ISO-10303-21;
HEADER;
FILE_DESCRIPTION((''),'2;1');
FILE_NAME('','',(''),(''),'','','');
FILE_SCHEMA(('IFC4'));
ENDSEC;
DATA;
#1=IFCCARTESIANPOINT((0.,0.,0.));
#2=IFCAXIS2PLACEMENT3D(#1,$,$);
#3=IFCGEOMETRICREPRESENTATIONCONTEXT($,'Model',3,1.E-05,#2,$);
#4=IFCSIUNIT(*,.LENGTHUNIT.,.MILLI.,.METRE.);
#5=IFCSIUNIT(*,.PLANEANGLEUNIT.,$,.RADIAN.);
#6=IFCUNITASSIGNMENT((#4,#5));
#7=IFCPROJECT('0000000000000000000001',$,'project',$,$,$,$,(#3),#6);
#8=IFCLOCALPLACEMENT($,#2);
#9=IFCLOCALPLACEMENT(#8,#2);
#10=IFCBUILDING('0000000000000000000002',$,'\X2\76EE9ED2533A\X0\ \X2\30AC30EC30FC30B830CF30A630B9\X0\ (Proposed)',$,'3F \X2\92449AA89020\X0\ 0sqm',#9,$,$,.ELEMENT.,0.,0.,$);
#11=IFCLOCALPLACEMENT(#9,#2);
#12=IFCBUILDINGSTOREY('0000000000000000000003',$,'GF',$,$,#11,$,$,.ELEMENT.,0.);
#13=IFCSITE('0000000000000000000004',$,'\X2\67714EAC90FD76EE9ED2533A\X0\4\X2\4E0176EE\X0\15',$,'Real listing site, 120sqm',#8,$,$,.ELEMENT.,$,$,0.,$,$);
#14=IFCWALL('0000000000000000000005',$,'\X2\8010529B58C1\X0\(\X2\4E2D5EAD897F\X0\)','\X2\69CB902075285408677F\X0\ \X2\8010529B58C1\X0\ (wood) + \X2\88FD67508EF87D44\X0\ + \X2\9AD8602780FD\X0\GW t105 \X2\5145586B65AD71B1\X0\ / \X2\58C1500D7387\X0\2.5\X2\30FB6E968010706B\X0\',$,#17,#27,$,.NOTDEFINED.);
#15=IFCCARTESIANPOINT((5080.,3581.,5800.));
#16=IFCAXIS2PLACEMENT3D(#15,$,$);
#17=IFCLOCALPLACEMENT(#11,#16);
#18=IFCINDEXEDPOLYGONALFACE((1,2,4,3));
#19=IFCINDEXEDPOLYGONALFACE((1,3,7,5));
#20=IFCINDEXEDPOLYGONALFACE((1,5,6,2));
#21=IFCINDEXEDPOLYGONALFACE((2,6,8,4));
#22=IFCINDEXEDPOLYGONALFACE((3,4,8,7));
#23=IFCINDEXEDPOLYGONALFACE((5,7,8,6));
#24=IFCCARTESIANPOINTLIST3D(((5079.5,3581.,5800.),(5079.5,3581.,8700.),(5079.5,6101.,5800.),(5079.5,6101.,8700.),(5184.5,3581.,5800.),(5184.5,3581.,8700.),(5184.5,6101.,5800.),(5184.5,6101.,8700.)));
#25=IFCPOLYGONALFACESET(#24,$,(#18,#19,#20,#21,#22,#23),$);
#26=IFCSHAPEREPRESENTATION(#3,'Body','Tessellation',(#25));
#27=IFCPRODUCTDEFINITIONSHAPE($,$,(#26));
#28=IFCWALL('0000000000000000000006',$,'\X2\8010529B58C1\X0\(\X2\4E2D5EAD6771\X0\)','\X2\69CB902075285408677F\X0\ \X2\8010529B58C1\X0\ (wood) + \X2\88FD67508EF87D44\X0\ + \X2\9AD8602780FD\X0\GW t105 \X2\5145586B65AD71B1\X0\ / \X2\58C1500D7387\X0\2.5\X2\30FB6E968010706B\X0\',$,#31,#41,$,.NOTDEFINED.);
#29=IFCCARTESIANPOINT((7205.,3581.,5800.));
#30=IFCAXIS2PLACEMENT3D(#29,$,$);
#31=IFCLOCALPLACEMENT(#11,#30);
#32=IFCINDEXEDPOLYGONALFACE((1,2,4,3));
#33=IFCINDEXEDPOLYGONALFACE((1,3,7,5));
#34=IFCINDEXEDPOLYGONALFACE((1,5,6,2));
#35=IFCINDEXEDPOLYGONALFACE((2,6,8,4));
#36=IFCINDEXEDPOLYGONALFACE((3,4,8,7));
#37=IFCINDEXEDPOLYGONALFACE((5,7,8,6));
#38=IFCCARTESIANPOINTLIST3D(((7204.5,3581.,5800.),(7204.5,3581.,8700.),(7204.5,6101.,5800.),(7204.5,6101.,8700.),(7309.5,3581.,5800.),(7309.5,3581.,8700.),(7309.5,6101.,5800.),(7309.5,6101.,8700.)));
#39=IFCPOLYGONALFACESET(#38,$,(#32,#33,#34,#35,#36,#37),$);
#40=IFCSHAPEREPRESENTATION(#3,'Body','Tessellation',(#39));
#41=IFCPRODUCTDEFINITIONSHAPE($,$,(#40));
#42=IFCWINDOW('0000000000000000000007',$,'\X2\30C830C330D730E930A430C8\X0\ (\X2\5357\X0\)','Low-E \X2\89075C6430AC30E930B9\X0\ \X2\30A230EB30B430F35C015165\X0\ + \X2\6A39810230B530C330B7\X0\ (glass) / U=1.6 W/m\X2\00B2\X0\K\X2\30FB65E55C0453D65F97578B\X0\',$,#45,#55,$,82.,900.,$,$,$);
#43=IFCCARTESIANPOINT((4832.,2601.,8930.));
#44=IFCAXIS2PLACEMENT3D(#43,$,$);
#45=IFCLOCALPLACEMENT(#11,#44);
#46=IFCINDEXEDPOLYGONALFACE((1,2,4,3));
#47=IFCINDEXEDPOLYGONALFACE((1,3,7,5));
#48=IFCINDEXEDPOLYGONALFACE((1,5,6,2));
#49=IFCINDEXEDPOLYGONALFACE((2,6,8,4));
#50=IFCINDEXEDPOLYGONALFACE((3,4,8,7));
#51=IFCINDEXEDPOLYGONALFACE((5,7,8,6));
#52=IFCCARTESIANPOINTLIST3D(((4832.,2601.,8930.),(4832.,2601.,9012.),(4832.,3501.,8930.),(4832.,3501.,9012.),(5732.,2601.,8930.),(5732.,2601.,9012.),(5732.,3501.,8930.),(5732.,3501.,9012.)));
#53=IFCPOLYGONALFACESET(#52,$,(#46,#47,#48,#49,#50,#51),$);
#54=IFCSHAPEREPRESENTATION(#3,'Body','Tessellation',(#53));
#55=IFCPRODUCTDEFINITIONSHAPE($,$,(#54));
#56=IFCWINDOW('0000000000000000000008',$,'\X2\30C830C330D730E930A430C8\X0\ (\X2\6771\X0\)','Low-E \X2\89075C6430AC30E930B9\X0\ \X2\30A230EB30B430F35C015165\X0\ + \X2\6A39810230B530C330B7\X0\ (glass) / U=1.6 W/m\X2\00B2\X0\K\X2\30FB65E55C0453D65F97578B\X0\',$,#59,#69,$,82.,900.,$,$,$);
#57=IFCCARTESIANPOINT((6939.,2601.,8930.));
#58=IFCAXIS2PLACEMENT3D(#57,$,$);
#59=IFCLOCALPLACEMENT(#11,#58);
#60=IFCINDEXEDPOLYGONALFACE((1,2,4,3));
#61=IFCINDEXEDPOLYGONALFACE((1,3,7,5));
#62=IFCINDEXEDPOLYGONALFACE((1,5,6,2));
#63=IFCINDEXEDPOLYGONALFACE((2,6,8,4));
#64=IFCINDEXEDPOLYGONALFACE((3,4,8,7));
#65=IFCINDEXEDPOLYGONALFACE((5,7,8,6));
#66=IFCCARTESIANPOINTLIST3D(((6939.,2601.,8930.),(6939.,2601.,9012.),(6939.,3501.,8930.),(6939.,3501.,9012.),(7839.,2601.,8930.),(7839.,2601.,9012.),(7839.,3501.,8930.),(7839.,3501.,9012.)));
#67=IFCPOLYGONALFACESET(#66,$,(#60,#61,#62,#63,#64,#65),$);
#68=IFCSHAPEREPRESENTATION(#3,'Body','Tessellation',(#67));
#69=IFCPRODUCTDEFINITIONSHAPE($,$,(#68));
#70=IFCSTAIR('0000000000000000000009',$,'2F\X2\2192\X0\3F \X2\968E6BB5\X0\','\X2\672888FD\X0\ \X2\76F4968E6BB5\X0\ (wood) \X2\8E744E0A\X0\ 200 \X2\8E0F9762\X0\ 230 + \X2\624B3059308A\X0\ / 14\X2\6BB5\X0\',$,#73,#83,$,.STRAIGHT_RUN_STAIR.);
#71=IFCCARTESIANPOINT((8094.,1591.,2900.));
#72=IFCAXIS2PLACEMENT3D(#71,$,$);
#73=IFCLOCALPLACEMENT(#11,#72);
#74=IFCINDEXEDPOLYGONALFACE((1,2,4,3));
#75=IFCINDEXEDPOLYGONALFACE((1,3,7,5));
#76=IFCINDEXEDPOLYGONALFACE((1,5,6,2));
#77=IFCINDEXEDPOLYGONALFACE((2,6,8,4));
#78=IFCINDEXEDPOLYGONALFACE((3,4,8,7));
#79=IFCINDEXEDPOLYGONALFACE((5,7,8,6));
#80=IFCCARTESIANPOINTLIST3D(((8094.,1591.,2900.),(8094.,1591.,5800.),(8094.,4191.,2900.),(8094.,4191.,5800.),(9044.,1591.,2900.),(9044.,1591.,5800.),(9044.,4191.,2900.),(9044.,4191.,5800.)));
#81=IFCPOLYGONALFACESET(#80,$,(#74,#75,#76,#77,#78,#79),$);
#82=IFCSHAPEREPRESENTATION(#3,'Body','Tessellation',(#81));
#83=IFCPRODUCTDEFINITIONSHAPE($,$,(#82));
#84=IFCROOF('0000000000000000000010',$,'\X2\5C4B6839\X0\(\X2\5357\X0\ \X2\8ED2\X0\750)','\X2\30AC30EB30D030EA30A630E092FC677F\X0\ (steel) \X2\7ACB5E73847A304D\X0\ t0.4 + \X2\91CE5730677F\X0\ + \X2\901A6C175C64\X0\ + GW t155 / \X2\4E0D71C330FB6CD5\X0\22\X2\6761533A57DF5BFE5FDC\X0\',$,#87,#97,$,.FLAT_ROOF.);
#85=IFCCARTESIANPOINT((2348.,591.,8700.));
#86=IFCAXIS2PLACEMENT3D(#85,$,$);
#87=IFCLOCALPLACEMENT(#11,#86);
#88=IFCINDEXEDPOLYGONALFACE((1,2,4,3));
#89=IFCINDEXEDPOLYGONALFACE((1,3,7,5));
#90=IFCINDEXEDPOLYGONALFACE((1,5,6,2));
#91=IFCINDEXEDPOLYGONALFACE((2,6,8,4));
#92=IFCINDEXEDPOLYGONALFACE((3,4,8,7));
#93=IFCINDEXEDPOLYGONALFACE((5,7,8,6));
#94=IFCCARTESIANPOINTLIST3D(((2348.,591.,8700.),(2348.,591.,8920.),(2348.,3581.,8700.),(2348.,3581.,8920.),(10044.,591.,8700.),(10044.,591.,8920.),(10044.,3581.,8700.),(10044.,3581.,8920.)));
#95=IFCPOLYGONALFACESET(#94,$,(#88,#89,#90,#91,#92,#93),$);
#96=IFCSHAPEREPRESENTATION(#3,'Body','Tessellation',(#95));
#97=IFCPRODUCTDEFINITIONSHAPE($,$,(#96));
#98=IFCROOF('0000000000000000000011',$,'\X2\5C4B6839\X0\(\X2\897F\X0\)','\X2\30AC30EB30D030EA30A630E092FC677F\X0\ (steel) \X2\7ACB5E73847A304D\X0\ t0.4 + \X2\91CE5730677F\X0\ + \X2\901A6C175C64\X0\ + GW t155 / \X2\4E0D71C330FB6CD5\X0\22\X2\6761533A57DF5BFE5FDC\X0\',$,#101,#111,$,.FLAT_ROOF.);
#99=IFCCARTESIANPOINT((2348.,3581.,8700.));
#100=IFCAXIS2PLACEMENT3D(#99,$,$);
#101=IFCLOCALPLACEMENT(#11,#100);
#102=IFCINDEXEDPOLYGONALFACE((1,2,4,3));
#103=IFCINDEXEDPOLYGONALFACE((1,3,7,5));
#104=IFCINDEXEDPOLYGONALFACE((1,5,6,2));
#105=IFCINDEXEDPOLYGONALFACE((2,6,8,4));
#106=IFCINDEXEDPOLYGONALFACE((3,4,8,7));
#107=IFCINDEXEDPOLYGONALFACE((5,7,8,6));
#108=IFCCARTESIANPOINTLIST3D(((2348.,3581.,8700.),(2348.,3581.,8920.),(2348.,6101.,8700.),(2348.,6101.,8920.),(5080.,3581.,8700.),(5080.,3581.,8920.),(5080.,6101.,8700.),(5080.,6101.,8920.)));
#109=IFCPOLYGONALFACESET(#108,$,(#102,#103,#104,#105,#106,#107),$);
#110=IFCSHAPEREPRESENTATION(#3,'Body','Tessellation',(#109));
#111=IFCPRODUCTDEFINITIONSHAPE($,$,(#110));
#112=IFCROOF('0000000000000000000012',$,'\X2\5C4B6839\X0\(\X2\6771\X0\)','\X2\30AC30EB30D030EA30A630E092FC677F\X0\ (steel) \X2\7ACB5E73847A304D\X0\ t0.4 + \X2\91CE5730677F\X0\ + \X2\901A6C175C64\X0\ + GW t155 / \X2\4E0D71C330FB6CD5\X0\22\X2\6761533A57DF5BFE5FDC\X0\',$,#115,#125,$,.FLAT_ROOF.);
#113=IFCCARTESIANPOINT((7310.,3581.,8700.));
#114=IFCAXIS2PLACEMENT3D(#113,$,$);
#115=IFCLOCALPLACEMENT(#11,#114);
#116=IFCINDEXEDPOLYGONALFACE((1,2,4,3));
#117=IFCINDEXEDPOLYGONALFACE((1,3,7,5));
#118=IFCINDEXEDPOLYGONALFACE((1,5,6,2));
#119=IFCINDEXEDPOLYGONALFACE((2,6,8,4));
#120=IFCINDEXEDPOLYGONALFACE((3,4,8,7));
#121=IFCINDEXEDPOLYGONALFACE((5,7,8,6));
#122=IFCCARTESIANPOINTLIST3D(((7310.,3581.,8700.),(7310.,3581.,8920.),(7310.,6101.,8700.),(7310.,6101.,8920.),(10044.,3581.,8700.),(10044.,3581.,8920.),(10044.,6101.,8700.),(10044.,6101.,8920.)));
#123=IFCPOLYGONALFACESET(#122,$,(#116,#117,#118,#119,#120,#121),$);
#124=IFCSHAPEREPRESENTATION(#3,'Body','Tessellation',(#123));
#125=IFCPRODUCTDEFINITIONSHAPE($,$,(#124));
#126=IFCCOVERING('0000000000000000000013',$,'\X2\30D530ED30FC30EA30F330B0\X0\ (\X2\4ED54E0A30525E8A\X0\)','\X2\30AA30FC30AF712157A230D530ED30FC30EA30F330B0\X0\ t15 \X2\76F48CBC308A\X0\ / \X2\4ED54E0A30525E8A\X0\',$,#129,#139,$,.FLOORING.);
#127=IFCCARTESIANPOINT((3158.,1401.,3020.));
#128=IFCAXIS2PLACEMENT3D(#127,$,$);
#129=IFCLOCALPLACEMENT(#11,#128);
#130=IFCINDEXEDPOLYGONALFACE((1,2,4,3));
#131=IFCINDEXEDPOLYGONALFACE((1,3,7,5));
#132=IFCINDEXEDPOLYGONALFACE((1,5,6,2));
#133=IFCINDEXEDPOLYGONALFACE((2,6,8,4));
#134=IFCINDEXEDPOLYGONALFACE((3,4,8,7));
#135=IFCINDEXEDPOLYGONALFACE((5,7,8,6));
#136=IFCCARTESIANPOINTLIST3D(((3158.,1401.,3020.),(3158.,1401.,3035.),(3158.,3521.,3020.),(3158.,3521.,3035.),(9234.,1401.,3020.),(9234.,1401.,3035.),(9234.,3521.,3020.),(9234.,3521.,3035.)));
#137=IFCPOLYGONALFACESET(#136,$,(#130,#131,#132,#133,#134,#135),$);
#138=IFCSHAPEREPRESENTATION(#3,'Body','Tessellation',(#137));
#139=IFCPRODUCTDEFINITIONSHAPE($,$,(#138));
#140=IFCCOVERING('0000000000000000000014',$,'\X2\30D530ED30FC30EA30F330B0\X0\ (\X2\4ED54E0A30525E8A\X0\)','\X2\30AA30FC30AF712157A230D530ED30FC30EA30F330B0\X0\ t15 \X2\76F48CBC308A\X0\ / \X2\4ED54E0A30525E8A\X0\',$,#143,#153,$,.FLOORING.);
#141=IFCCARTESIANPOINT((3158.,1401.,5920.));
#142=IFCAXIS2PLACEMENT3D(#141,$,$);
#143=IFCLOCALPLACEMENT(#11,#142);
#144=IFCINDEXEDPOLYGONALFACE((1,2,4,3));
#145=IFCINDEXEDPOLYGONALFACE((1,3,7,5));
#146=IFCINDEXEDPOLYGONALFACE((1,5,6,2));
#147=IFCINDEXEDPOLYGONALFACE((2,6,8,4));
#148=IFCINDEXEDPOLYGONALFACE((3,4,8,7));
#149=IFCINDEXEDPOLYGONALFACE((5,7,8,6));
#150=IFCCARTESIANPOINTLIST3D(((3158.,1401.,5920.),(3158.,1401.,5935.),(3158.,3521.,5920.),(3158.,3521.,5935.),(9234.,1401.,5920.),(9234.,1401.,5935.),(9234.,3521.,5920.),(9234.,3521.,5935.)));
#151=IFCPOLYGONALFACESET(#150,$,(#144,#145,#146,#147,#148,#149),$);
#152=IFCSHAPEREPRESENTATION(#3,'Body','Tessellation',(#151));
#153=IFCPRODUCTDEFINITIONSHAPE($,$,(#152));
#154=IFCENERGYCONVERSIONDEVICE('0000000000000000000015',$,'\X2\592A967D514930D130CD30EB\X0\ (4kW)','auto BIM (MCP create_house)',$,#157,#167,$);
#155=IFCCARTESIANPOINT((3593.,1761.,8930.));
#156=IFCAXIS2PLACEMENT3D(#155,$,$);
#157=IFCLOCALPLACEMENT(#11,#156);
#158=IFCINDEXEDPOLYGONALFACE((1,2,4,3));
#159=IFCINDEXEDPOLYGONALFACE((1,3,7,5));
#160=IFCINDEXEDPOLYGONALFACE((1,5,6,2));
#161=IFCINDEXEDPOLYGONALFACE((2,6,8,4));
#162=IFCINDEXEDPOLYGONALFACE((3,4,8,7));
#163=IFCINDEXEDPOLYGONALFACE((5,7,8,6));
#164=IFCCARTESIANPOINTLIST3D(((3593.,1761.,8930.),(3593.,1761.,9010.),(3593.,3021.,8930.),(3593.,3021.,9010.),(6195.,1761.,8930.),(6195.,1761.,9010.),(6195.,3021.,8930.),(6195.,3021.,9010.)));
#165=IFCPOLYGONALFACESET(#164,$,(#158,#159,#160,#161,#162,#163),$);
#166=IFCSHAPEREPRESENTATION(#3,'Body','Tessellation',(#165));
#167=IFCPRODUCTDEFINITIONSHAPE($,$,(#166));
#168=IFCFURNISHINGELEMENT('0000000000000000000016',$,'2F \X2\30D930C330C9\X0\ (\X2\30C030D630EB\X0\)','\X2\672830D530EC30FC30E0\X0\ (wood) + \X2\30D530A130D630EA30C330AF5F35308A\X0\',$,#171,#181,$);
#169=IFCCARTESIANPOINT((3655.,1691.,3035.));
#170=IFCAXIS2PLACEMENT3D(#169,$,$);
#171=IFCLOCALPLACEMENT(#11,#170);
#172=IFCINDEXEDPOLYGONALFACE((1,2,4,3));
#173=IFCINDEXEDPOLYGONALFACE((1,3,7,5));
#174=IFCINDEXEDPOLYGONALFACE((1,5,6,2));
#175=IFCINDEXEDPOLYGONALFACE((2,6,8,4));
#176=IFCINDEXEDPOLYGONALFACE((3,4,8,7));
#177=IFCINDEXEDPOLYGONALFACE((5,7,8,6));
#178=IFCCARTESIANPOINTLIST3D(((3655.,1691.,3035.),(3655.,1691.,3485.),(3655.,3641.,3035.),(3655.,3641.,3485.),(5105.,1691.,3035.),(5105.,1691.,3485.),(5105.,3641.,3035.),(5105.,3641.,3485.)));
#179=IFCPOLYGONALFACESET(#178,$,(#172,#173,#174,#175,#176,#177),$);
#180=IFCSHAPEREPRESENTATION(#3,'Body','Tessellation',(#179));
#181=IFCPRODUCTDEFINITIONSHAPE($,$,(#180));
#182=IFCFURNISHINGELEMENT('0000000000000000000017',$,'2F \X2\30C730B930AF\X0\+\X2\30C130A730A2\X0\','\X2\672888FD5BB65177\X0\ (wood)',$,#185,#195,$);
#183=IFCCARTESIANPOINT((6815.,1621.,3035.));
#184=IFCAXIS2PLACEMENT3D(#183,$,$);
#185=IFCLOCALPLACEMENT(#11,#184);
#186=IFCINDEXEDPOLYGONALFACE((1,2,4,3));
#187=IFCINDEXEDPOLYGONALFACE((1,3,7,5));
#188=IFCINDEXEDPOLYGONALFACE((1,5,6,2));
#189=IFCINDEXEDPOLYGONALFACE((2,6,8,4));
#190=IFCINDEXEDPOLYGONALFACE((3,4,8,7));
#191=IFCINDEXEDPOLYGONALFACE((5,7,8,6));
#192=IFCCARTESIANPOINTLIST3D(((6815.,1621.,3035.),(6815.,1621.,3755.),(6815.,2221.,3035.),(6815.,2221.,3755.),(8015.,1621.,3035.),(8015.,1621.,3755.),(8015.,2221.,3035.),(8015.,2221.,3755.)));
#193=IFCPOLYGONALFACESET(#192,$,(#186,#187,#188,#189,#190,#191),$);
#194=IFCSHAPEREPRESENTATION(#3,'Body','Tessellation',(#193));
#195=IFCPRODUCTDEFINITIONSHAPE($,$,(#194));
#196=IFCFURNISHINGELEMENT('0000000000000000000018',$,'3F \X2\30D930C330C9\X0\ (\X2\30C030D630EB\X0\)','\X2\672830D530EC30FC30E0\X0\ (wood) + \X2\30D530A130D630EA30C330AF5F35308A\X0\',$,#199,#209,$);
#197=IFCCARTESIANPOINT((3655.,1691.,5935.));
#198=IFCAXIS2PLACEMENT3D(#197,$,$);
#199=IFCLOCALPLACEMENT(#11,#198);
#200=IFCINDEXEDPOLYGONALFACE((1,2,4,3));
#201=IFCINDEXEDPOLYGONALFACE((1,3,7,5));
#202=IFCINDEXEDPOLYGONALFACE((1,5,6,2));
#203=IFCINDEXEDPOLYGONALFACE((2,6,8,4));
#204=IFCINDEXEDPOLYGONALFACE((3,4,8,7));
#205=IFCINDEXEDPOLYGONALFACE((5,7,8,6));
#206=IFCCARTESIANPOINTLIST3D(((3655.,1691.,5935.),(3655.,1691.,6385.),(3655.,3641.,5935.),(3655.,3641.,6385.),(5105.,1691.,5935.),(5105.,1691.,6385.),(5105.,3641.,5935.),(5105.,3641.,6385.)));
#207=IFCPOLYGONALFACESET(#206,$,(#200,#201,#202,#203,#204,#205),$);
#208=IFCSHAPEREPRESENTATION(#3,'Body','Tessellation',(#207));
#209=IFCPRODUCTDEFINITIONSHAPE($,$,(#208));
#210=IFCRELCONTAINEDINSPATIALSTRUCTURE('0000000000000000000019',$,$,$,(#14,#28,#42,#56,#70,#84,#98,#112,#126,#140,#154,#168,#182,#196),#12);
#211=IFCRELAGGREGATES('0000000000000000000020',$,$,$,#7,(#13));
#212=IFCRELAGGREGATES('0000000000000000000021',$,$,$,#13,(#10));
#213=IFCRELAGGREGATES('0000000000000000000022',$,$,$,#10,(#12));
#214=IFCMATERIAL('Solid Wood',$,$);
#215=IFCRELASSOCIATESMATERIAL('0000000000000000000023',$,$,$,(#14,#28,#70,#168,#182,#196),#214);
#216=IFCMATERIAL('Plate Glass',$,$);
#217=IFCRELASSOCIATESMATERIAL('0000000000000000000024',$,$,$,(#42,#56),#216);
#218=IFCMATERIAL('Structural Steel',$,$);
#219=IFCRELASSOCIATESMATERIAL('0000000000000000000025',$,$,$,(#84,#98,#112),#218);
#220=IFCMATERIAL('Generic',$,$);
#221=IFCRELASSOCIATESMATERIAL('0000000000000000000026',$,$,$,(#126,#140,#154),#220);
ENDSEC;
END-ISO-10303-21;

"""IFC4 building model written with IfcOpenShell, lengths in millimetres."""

from ifc_helpers import new_model, si_unit, frame, frame_2d, origin, place, context, project, spatial, rectangle, extrude, material, element, save


model = new_model("IFC4")

# Units and contexts
model_context = context("Model", 3, precision=1e-05, world=origin())
ifc_project = project(units=[si_unit("LENGTHUNIT", "METRE", prefix="MILLI"), si_unit("PLANEANGLEUNIT", "RADIAN")], contexts=[model_context])

# Site, building, storey
site_placement = place(None, origin())
site = spatial("IfcSite", under=ifc_project, at=site_placement, Name="東京都目黒区4丁目15", ObjectType="Real listing site, 120sqm", CompositionType="ELEMENT", RefElevation=0.0)
building_placement = place(site_placement, origin())
building = spatial("IfcBuilding", under=site, at=building_placement, Name="目黒区 ガレージハウス (Proposed)", ObjectType="3F 鉄骨造 0sqm", CompositionType="ELEMENT", ElevationOfRefHeight=0.0, ElevationOfTerrain=0.0)
storey_placement = place(building_placement, origin())
storey = spatial("IfcBuildingStorey", under=building, at=storey_placement, Name="GF", CompositionType="ELEMENT", Elevation=0.0)

# Shared definitions
ifc_material_1 = material(Name="Solid Wood")

# Shared definitions
ifc_material_2 = material(Name="Plate Glass")

# Walls
wall_1_placement = place(storey_placement, frame((5080.0, 3581.0, 5800.0)))
element("IfcWall", 1, at=wall_1_placement, inside=storey, material=ifc_material_1, Name="耐力壁(中庭西)", Description="構造用合板 耐力壁 (wood) + 製材軸組 + 高性能GW t105 充填断熱 / 壁倍率2.5・準耐火", PredefinedType="NOTDEFINED", context=model_context, shape_type="SweptSolid", body=[
    extrude(rectangle(XDim=105.0, YDim=2520.0, at=frame_2d((52.0, 1260.0))), frame((5080.0, 3581.0, 5800.0)), (0.0, 0.0, 1.0), 2900.0),
])
wall_2_placement = place(storey_placement, frame((7205.0, 3581.0, 5800.0)))
element("IfcWall", 2, at=wall_2_placement, inside=storey, material=ifc_material_1, Name="耐力壁(中庭東)", Description="構造用合板 耐力壁 (wood) + 製材軸組 + 高性能GW t105 充填断熱 / 壁倍率2.5・準耐火", PredefinedType="NOTDEFINED", context=model_context, shape_type="SweptSolid", body=[
    extrude(rectangle(XDim=105.0, YDim=2520.0, at=frame_2d((52.0, 1260.0))), frame((7205.0, 3581.0, 5800.0)), (0.0, 0.0, 1.0), 2900.0),
])

# Windows
window_1_placement = place(storey_placement, frame((4832.0, 2601.0, 8930.0)))
element("IfcWindow", 3, at=window_1_placement, inside=storey, material=ifc_material_2, Name="トップライト (南)", Description="Low-E 複層ガラス アルゴン封入 + 樹脂サッシ (glass) / U=1.6 W/m²K・日射取得型", OverallHeight=82.0, OverallWidth=900.0, context=model_context, shape_type="SweptSolid", body=[
    extrude(rectangle(XDim=900.0, YDim=900.0, at=frame_2d((450.0, 450.0))), frame((4832.0, 2601.0, 8930.0)), (0.0, 0.0, 1.0), 82.0),
])
window_2_placement = place(storey_placement, frame((6939.0, 2601.0, 8930.0)))
element("IfcWindow", 4, at=window_2_placement, inside=storey, material=ifc_material_2, Name="トップライト (東)", Description="Low-E 複層ガラス アルゴン封入 + 樹脂サッシ (glass) / U=1.6 W/m²K・日射取得型", OverallHeight=82.0, OverallWidth=900.0, context=model_context, shape_type="SweptSolid", body=[
    extrude(rectangle(XDim=900.0, YDim=900.0, at=frame_2d((450.0, 450.0))), frame((6939.0, 2601.0, 8930.0)), (0.0, 0.0, 1.0), 82.0),
])

# Stair
stair_placement = place(storey_placement, frame((8094.0, 1591.0, 2900.0)))
element("IfcStair", 5, at=stair_placement, inside=storey, material=ifc_material_1, Name="2F→3F 階段", Description="木製 直階段 (wood) 蹴上 200 踏面 230 + 手すり / 14段", PredefinedType="STRAIGHT_RUN_STAIR", context=model_context, shape_type="SweptSolid", body=[
    extrude(rectangle(XDim=950.0, YDim=2600.0, at=frame_2d((475.0, 1300.0))), frame((8094.0, 1591.0, 2900.0)), (0.0, 0.0, 1.0), 2900.0),
])

# Roofs
ifc_material_3 = material(Name="Structural Steel")
roof_1_placement = place(storey_placement, frame((2348.0, 591.0, 8700.0)))
element("IfcRoof", 6, at=roof_1_placement, inside=storey, material=ifc_material_3, Name="屋根(南 軒750)", Description="ガルバリウム鋼板 (steel) 立平葺き t0.4 + 野地板 + 通気層 + GW t155 / 不燃・法22条区域対応", PredefinedType="FLAT_ROOF", context=model_context, shape_type="SweptSolid", body=[
    extrude(rectangle(XDim=7696.0, YDim=2990.0, at=frame_2d((3848.0, 1495.0))), frame((2348.0, 591.0, 8700.0)), (0.0, 0.0, 1.0), 220.0),
])
roof_2_placement = place(storey_placement, frame((2348.0, 3581.0, 8700.0)))
element("IfcRoof", 7, at=roof_2_placement, inside=storey, material=ifc_material_3, Name="屋根(西)", Description="ガルバリウム鋼板 (steel) 立平葺き t0.4 + 野地板 + 通気層 + GW t155 / 不燃・法22条区域対応", PredefinedType="FLAT_ROOF", context=model_context, shape_type="SweptSolid", body=[
    extrude(rectangle(XDim=2732.0, YDim=2520.0, at=frame_2d((1366.0, 1260.0))), frame((2348.0, 3581.0, 8700.0)), (0.0, 0.0, 1.0), 220.0),
])
roof_3_placement = place(storey_placement, frame((7310.0, 3581.0, 8700.0)))
element("IfcRoof", 8, at=roof_3_placement, inside=storey, material=ifc_material_3, Name="屋根(東)", Description="ガルバリウム鋼板 (steel) 立平葺き t0.4 + 野地板 + 通気層 + GW t155 / 不燃・法22条区域対応", PredefinedType="FLAT_ROOF", context=model_context, shape_type="SweptSolid", body=[
    extrude(rectangle(XDim=2734.0, YDim=2520.0, at=frame_2d((1367.0, 1260.0))), frame((7310.0, 3581.0, 8700.0)), (0.0, 0.0, 1.0), 220.0),
])

# Coverings
ifc_material_4 = material(Name="Generic")
covering_1_placement = place(storey_placement, frame((3158.0, 1401.0, 3020.0)))
element("IfcCovering", 9, at=covering_1_placement, inside=storey, material=ifc_material_4, Name="フローリング (仕上げ床)", Description="オーク無垢フローリング t15 直貼り / 仕上げ床", PredefinedType="FLOORING", context=model_context, shape_type="SweptSolid", body=[
    extrude(rectangle(XDim=6076.0, YDim=2120.0, at=frame_2d((3038.0, 1060.0))), frame((3158.0, 1401.0, 3020.0)), (0.0, 0.0, 1.0), 15.0),
])
covering_2_placement = place(storey_placement, frame((3158.0, 1401.0, 5920.0)))
element("IfcCovering", 10, at=covering_2_placement, inside=storey, material=ifc_material_4, Name="フローリング (仕上げ床)", Description="オーク無垢フローリング t15 直貼り / 仕上げ床", PredefinedType="FLOORING", context=model_context, shape_type="SweptSolid", body=[
    extrude(rectangle(XDim=6076.0, YDim=2120.0, at=frame_2d((3038.0, 1060.0))), frame((3158.0, 1401.0, 5920.0)), (0.0, 0.0, 1.0), 15.0),
])

# Energy conversion device
energy_conversion_device_placement = place(storey_placement, frame((3593.0, 1761.0, 8930.0)))
element("IfcEnergyConversionDevice", 11, at=energy_conversion_device_placement, inside=storey, material=ifc_material_4, Name="太陽光パネル (4kW)", Description="auto BIM (MCP create_house)", context=model_context, shape_type="SweptSolid", body=[
    extrude(rectangle(XDim=2602.0, YDim=1260.0, at=frame_2d((1301.0, 630.0))), frame((3593.0, 1761.0, 8930.0)), (0.0, 0.0, 1.0), 80.0),
])

# Furnishing elements
furnishing_1_placement = place(storey_placement, frame((3655.0, 1691.0, 3035.0)))
element("IfcFurnishingElement", 12, at=furnishing_1_placement, inside=storey, material=ifc_material_1, Name="2F ベッド (ダブル)", Description="木フレーム (wood) + ファブリック張り", context=model_context, shape_type="SweptSolid", body=[
    extrude(rectangle(XDim=1450.0, YDim=1950.0, at=frame_2d((725.0, 975.0))), frame((3655.0, 1691.0, 3035.0)), (0.0, 0.0, 1.0), 450.0),
])
furnishing_2_placement = place(storey_placement, frame((6815.0, 1621.0, 3035.0)))
element("IfcFurnishingElement", 13, at=furnishing_2_placement, inside=storey, material=ifc_material_1, Name="2F デスク+チェア", Description="木製家具 (wood)", context=model_context, shape_type="SweptSolid", body=[
    extrude(rectangle(XDim=1200.0, YDim=600.0, at=frame_2d((600.0, 300.0))), frame((6815.0, 1621.0, 3035.0)), (0.0, 0.0, 1.0), 720.0),
])
furnishing_3_placement = place(storey_placement, frame((3655.0, 1691.0, 5935.0)))
element("IfcFurnishingElement", 14, at=furnishing_3_placement, inside=storey, material=ifc_material_1, Name="3F ベッド (ダブル)", Description="木フレーム (wood) + ファブリック張り", context=model_context, shape_type="SweptSolid", body=[
    extrude(rectangle(XDim=1450.0, YDim=1950.0, at=frame_2d((725.0, 975.0))), frame((3655.0, 1691.0, 5935.0)), (0.0, 0.0, 1.0), 450.0),
])

save(model, "model.ifc")
